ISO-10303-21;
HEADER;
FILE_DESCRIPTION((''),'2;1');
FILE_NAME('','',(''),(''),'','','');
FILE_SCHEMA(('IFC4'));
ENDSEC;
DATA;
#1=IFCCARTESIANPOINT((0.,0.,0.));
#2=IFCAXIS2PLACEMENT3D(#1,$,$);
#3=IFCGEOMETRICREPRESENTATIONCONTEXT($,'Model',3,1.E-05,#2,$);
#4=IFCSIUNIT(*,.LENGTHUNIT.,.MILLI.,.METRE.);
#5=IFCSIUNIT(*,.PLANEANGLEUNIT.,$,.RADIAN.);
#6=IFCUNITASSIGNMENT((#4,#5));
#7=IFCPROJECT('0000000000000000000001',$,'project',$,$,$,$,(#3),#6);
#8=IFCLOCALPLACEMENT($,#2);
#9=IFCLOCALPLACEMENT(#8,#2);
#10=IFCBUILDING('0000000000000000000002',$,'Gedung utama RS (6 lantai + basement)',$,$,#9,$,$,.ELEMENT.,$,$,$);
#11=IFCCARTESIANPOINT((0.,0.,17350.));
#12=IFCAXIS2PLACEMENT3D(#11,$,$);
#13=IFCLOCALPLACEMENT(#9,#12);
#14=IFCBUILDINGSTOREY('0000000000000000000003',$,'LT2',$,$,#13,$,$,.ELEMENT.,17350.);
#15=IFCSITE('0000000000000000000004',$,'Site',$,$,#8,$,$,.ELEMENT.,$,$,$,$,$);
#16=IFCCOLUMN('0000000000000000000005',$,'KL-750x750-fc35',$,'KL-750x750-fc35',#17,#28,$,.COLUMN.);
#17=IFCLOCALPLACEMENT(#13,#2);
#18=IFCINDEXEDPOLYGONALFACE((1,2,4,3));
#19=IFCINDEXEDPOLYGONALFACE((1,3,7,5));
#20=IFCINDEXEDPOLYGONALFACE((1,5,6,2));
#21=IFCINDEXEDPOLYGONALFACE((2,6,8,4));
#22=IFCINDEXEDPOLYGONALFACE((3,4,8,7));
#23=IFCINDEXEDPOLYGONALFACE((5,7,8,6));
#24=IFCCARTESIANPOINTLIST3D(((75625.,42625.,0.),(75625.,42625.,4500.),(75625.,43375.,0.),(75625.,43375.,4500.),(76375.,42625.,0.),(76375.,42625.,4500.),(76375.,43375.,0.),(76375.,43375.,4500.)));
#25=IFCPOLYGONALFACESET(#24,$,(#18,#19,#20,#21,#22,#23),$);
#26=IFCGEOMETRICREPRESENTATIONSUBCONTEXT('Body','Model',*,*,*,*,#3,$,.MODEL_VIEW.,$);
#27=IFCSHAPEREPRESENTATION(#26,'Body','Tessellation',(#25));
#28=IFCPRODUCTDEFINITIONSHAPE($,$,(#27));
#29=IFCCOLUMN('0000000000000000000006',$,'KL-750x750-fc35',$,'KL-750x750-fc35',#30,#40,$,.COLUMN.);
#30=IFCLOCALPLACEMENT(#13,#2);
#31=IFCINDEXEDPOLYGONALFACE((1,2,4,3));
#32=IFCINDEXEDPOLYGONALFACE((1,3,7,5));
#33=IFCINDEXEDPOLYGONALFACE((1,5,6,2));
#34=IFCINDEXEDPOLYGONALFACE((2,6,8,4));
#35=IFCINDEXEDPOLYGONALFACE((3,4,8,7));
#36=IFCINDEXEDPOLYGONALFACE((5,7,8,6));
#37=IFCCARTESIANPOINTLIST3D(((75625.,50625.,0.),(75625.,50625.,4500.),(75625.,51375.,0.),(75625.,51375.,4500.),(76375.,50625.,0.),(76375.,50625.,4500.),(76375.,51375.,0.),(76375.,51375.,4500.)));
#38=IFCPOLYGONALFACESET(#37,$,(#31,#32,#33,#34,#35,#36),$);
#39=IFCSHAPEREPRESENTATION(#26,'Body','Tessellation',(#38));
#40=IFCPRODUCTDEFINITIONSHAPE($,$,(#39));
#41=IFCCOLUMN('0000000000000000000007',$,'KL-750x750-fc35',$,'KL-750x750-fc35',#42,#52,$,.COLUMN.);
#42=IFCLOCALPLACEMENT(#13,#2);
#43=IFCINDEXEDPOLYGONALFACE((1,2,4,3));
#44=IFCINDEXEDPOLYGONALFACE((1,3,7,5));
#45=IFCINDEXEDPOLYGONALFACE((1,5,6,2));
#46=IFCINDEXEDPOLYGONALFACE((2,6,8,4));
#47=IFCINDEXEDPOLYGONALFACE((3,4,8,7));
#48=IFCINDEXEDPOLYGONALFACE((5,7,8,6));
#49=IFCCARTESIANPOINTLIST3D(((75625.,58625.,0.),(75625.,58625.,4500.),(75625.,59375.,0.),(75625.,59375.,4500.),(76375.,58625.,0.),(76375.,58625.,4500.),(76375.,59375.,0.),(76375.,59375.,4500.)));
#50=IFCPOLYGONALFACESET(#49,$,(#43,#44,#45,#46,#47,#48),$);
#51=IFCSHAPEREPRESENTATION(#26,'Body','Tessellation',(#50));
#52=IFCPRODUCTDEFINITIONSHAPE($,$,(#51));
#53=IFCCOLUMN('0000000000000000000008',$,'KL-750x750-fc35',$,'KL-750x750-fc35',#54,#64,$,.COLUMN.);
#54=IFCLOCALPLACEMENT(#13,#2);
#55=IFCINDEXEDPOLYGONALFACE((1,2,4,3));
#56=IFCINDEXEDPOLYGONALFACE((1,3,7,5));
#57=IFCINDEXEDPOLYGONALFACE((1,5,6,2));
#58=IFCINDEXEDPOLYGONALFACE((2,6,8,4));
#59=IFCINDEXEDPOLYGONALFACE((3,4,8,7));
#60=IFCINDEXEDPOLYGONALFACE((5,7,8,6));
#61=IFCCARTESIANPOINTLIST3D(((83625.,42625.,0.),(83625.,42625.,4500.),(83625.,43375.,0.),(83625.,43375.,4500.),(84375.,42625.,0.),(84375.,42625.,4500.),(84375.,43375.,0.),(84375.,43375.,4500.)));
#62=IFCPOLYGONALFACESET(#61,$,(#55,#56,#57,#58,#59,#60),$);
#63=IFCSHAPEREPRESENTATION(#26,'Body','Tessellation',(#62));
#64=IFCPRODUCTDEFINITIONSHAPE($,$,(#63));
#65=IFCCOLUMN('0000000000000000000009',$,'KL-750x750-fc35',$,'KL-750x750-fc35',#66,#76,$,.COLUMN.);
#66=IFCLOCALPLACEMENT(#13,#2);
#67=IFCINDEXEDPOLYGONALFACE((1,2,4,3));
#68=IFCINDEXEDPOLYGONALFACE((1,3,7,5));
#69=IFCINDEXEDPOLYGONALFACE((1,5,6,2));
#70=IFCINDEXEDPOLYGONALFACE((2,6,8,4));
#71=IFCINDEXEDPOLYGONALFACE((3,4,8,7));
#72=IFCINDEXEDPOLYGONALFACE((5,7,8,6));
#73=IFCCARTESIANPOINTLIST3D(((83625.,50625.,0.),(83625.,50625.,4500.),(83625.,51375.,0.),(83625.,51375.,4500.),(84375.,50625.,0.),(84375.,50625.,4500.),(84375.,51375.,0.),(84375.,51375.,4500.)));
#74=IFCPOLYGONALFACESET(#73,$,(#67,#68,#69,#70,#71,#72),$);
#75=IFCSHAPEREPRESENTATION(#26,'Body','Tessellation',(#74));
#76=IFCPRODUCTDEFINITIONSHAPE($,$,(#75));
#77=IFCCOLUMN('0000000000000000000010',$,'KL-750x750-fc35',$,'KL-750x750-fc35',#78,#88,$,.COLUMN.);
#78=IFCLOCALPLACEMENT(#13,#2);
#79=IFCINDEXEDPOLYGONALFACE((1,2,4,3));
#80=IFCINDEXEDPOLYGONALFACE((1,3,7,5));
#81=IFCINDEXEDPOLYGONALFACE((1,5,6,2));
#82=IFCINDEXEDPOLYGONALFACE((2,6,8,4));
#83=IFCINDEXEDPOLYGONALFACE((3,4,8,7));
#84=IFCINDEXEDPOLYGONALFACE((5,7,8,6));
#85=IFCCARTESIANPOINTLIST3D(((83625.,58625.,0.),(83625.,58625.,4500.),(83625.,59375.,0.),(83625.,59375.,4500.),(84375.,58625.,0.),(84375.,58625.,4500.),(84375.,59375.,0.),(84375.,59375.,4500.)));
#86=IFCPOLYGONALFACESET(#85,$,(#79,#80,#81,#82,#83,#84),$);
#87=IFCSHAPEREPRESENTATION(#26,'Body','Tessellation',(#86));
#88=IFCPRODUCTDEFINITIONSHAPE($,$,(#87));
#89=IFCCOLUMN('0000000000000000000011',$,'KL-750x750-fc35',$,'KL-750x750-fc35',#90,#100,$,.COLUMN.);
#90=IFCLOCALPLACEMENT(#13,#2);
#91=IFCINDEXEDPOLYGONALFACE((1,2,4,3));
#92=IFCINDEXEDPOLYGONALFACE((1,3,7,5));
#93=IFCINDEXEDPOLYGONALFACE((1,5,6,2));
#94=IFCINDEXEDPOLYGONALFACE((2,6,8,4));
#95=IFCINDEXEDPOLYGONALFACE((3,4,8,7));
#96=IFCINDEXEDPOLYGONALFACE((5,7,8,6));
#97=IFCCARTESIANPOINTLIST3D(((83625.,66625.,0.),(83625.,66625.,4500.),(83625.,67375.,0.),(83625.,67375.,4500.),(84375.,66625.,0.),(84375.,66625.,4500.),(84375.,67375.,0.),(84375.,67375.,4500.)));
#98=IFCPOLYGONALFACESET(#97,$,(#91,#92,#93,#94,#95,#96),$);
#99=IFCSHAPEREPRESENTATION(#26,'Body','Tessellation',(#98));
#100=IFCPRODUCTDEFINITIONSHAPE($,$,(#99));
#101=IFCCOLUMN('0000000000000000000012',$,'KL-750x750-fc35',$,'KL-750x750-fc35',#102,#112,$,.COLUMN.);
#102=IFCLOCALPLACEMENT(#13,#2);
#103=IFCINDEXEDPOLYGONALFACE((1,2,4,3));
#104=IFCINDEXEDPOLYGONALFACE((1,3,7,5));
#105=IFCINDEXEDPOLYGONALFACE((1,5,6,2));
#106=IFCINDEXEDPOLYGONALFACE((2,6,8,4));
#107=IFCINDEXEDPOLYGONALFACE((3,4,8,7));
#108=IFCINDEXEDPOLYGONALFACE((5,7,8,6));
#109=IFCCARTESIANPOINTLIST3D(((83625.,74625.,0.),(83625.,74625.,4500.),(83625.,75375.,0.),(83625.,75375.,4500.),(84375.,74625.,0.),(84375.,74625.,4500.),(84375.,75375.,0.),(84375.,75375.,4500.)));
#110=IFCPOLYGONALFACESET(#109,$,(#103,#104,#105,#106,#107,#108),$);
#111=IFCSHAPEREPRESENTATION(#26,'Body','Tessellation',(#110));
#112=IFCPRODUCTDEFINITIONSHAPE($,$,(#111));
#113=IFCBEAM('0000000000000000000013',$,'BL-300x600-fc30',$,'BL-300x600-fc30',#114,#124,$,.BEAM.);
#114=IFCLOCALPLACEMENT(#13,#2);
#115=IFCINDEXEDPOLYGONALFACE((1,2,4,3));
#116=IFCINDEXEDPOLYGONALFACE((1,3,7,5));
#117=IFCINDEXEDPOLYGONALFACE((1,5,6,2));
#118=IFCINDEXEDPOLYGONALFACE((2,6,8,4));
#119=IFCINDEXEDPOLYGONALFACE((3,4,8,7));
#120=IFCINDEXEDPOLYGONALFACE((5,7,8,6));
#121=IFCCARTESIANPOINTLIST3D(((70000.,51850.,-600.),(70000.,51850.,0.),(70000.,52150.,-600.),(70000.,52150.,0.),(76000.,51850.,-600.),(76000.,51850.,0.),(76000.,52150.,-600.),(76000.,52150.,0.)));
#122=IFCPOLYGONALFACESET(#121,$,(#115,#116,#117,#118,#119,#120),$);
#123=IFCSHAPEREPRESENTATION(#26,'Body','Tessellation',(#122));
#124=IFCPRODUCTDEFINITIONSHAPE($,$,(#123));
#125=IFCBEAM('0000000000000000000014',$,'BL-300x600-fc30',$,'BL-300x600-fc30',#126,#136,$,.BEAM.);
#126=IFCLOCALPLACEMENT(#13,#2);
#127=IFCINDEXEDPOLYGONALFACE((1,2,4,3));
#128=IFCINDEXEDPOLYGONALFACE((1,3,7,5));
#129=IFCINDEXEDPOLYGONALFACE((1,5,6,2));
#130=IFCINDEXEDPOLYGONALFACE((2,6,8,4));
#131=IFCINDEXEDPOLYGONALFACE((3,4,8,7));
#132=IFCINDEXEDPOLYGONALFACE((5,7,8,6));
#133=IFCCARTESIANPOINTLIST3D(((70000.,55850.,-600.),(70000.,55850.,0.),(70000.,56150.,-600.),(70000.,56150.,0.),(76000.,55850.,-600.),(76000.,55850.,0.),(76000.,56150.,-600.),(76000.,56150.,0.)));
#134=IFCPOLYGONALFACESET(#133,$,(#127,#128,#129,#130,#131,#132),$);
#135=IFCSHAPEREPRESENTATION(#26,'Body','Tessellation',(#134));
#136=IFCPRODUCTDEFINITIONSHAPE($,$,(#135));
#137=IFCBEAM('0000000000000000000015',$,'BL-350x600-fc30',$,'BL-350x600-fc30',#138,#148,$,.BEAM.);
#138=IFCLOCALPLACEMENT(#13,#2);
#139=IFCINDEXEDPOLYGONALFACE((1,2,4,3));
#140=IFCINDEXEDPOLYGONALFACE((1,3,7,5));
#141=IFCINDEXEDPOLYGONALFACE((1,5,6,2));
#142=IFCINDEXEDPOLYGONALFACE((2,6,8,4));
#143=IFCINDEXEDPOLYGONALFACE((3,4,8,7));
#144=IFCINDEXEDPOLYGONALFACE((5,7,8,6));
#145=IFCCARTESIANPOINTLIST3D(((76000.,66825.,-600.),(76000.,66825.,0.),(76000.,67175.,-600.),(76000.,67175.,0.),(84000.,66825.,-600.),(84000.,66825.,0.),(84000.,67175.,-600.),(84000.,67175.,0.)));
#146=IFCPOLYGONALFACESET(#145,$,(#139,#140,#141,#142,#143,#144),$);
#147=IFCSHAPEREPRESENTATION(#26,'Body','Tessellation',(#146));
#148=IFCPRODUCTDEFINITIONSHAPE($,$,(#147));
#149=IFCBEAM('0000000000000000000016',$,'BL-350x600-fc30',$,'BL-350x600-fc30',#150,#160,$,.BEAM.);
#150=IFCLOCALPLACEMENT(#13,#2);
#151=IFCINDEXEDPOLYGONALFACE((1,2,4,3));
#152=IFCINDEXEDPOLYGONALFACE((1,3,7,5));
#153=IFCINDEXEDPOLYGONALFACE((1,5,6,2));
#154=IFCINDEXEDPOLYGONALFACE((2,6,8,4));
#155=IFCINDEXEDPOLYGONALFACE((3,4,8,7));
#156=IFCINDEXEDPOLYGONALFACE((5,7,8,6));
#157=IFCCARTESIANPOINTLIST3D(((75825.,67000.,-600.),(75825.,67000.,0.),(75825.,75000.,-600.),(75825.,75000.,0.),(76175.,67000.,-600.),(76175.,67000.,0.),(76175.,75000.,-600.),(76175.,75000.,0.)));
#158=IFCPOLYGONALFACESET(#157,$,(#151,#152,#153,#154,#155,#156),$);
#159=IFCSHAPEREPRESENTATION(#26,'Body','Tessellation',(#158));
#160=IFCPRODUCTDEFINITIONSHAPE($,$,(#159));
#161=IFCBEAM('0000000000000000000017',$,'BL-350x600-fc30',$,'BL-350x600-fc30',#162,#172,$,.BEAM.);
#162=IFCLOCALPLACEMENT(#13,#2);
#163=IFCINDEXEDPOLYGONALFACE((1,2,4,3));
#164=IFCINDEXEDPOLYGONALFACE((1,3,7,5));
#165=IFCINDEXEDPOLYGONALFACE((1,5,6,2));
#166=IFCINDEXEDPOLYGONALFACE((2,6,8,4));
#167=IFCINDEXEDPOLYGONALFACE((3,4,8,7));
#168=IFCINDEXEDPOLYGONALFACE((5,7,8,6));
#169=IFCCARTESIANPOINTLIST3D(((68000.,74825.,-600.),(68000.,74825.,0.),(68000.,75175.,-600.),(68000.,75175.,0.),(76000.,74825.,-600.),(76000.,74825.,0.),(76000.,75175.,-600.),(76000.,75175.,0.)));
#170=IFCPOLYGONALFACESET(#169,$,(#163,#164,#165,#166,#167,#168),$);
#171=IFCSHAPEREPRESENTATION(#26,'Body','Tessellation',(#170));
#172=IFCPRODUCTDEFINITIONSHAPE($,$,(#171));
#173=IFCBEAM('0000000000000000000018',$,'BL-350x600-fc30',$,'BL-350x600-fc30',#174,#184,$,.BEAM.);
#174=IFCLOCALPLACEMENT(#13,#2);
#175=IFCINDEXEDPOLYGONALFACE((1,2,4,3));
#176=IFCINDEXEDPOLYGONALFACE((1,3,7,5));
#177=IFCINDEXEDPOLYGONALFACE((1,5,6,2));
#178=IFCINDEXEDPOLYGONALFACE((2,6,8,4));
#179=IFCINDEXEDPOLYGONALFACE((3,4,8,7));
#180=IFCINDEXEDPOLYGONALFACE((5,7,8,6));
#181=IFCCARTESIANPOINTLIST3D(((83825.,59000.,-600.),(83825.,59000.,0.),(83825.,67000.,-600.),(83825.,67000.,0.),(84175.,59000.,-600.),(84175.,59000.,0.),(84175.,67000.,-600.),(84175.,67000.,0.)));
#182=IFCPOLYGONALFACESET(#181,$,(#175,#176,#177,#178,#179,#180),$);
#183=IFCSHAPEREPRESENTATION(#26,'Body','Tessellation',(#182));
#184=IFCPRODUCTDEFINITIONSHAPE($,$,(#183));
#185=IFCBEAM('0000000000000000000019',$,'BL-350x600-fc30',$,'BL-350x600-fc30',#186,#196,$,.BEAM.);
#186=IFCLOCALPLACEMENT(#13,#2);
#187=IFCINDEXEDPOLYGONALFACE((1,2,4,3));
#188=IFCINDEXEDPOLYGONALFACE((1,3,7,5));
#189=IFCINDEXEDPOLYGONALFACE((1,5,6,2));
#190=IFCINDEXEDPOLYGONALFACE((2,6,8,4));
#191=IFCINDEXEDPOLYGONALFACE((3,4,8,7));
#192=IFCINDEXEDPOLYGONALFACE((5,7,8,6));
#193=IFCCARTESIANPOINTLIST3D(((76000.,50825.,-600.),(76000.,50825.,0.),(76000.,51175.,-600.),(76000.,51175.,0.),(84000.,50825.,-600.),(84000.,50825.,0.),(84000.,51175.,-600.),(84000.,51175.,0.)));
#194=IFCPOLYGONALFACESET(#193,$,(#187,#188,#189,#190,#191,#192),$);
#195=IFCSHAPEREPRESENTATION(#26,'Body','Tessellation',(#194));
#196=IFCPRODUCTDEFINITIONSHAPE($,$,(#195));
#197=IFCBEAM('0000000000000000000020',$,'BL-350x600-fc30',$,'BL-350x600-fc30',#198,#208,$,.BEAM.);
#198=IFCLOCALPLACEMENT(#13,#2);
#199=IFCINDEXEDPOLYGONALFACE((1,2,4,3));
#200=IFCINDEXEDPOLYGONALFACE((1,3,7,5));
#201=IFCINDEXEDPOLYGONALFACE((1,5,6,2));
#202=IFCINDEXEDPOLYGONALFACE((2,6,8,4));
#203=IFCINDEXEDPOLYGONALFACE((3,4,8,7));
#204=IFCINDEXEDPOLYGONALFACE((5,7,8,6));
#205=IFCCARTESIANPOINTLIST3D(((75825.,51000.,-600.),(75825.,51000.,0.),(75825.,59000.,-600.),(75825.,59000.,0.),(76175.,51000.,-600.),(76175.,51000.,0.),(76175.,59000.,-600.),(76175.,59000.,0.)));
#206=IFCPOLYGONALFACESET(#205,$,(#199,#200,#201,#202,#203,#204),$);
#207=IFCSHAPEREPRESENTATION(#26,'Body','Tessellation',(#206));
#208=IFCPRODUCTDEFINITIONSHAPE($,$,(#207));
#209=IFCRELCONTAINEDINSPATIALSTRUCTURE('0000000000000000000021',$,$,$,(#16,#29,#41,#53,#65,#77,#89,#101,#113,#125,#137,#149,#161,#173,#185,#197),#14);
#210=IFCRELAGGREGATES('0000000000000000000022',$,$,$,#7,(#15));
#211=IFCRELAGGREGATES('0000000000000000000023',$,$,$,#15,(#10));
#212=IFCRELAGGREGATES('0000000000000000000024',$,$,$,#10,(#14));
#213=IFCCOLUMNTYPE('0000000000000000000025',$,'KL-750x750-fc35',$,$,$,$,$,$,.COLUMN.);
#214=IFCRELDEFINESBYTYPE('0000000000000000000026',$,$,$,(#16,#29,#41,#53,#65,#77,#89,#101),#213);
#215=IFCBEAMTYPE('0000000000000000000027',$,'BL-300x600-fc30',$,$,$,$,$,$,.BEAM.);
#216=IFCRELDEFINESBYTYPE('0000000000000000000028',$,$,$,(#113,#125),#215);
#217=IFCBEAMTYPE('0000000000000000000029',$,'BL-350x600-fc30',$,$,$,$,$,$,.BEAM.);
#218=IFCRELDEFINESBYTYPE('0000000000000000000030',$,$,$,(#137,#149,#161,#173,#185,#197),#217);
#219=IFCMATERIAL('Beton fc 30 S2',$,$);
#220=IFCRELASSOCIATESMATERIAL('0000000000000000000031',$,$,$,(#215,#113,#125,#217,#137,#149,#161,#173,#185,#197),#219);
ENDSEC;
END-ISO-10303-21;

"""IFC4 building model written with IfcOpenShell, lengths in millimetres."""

from ifc_helpers import new_model, si_unit, frame, origin, origin_2d, place, context, subcontext, project, spatial, rectangle, extrude, material, material_profile, profile_set, profile_usage, type_object, element, save


model = new_model("IFC4")

# Units and contexts
model_context = context("Model", 3, precision=1e-05, world=origin())
body_context = subcontext(model_context, "Body", "Model", "MODEL_VIEW")
ifc_project = project(units=[si_unit("LENGTHUNIT", "METRE", prefix="MILLI"), si_unit("PLANEANGLEUNIT", "RADIAN")], contexts=[model_context])

# Site, building, storey
site_placement = place(None, origin())
site = spatial("IfcSite", under=ifc_project, at=site_placement, Name="Site", CompositionType="ELEMENT")
building_placement = place(site_placement, origin())
building = spatial("IfcBuilding", under=site, at=building_placement, Name="Gedung utama RS (6 lantai + basement)", CompositionType="ELEMENT")
storey_placement = place(building_placement, frame((0.0, 0.0, 17350.0)))
storey = spatial("IfcBuildingStorey", under=building, at=storey_placement, Name="LT2", CompositionType="ELEMENT", Elevation=17350.0)

# Columns
ifc_material_profile_1 = material_profile(None, rectangle(XDim=750.0, YDim=750.0, at=origin_2d()), Name="KL-750x750-fc35")
ifc_profile_set_1 = profile_set([ifc_material_profile_1], Name="KL-750x750-fc35")
ifc_profile_usage_1 = profile_usage(ifc_profile_set_1, cardinal=5)
column_type = type_object("IfcColumnType", Name="KL-750x750-fc35", PredefinedType="COLUMN", material=ifc_profile_set_1)
for number, where, z_axis, x_axis, name in (
    (1, (76000.0, 43000.0, 0.0), (0.0, 0.0, 1.0), (1.0, 0.0, 0.0), "KL-750x750-fc35"),
    (2, (76000.0, 51000.0, 0.0), (0.0, 0.0, 1.0), (1.0, 0.0, 0.0), "KL-750x750-fc35"),
    (3, (76000.0, 59000.0, 0.0), (0.0, 0.0, 1.0), (1.0, 0.0, 0.0), "KL-750x750-fc35"),
    (4, (84000.0, 43000.0, 0.0), (0.0, 0.0, 1.0), (1.0, 0.0, 0.0), "KL-750x750-fc35"),
    (5, (84000.0, 51000.0, 0.0), (0.0, 0.0, 1.0), (1.0, 0.0, 0.0), "KL-750x750-fc35"),
    (6, (84000.0, 59000.0, 0.0), (0.0, 0.0, 1.0), (1.0, 0.0, 0.0), "KL-750x750-fc35"),
    (7, (84000.0, 67000.0, 0.0), (0.0, 0.0, 1.0), (1.0, 0.0, 0.0), "KL-750x750-fc35"),
    (8, (84000.0, 75000.0, 0.0), (0.0, 0.0, 1.0), (1.0, 0.0, 0.0), "KL-750x750-fc35"),
):
    element("IfcColumn", number, at=place(storey_placement, frame(where, z_axis=z_axis, x_axis=x_axis)), inside=storey, type_object=column_type, material=ifc_profile_usage_1, Name=name, ObjectType="KL-750x750-fc35", PredefinedType="COLUMN", context=body_context, shape_type="SweptSolid", body=[
        extrude(rectangle(XDim=750.0, YDim=750.0, at=origin_2d()), origin(), (0.0, 0.0, 1.0), 4500.0),
    ])

# Beams
ifc_material_1 = material(Name="Beton fc 30 S2")
ifc_material_profile_2 = material_profile(ifc_material_1, rectangle(XDim=300.0, YDim=600.0, at=origin_2d()), Name="BL-300x600-fc30")
ifc_profile_set_2 = profile_set([ifc_material_profile_2], Name="BL-300x600-fc30")
ifc_profile_usage_2 = profile_usage(ifc_profile_set_2, cardinal=8)
beam_type_1 = type_object("IfcBeamType", Name="BL-300x600-fc30", PredefinedType="BEAM", material=ifc_profile_set_2)
for number, where, name in (
    (9, (70000.0, 52000.0, -300.0), "BL-300x600-fc30"),
    (10, (70000.0, 56000.0, -300.0), "BL-300x600-fc30"),
):
    element("IfcBeam", number, at=place(storey_placement, frame(where)), inside=storey, type_object=beam_type_1, material=ifc_profile_usage_2, Name=name, ObjectType="BL-300x600-fc30", PredefinedType="BEAM", context=body_context, shape_type="SweptSolid", body=[
        extrude(rectangle(XDim=300.0, YDim=600.0, at=origin_2d()), frame((0.0, 0.0, 0.0), z_axis=(1.0, 0.0, 0.0), x_axis=(0.0, 1.0, 0.0)), (0.0, 0.0, 1.0), 6000.0),
    ])
ifc_material_profile_3 = material_profile(ifc_material_1, rectangle(XDim=350.0, YDim=600.0, at=origin_2d()), Name="BL-350x600-fc30")
ifc_profile_set_3 = profile_set([ifc_material_profile_3], Name="BL-350x600-fc30")
ifc_profile_usage_3 = profile_usage(ifc_profile_set_3, cardinal=8)
beam_type_2 = type_object("IfcBeamType", Name="BL-350x600-fc30", PredefinedType="BEAM", material=ifc_profile_set_3)
beam_1_placement = place(storey_placement, frame((76000.0, 67000.0, -300.0)))
element("IfcBeam", 11, at=beam_1_placement, inside=storey, type_object=beam_type_2, material=ifc_profile_usage_3, Name="BL-350x600-fc30", ObjectType="BL-350x600-fc30", PredefinedType="BEAM", context=body_context, shape_type="SweptSolid", body=[
    extrude(rectangle(XDim=350.0, YDim=600.0, at=origin_2d()), frame((0.0, 0.0, 0.0), z_axis=(1.0, 0.0, 0.0), x_axis=(0.0, 1.0, 0.0)), (0.0, 0.0, 1.0), 8000.0),
])
beam_2_placement = place(storey_placement, frame((76000.0, 67000.0, -300.0)))
element("IfcBeam", 12, at=beam_2_placement, inside=storey, type_object=beam_type_2, material=ifc_profile_usage_3, Name="BL-350x600-fc30", ObjectType="BL-350x600-fc30", PredefinedType="BEAM", context=body_context, shape_type="SweptSolid", body=[
    extrude(rectangle(XDim=350.0, YDim=600.0, at=origin_2d()), frame((0.0, 0.0, 0.0), z_axis=(0.0, 1.0, 0.0), x_axis=(-1.0, 0.0, 0.0)), (0.0, 0.0, 1.0), 8000.0),
])
beam_3_placement = place(storey_placement, frame((68000.0, 75000.0, -300.0)))
element("IfcBeam", 13, at=beam_3_placement, inside=storey, type_object=beam_type_2, material=ifc_profile_usage_3, Name="BL-350x600-fc30", ObjectType="BL-350x600-fc30", PredefinedType="BEAM", context=body_context, shape_type="SweptSolid", body=[
    extrude(rectangle(XDim=350.0, YDim=600.0, at=origin_2d()), frame((0.0, 0.0, 0.0), z_axis=(1.0, 0.0, 0.0), x_axis=(0.0, 1.0, 0.0)), (0.0, 0.0, 1.0), 8000.0),
])
beam_4_placement = place(storey_placement, frame((84000.0, 59000.0, -300.0)))
element("IfcBeam", 14, at=beam_4_placement, inside=storey, type_object=beam_type_2, material=ifc_profile_usage_3, Name="BL-350x600-fc30", ObjectType="BL-350x600-fc30", PredefinedType="BEAM", context=body_context, shape_type="SweptSolid", body=[
    extrude(rectangle(XDim=350.0, YDim=600.0, at=origin_2d()), frame((0.0, 0.0, 0.0), z_axis=(0.0, 1.0, 0.0), x_axis=(-1.0, 0.0, 0.0)), (0.0, 0.0, 1.0), 8000.0),
])
beam_5_placement = place(storey_placement, frame((76000.0, 51000.0, -300.0)))
element("IfcBeam", 15, at=beam_5_placement, inside=storey, type_object=beam_type_2, material=ifc_profile_usage_3, Name="BL-350x600-fc30", ObjectType="BL-350x600-fc30", PredefinedType="BEAM", context=body_context, shape_type="SweptSolid", body=[
    extrude(rectangle(XDim=350.0, YDim=600.0, at=origin_2d()), frame((0.0, 0.0, 0.0), z_axis=(1.0, 0.0, 0.0), x_axis=(0.0, 1.0, 0.0)), (0.0, 0.0, 1.0), 8000.0),
])
for number, where, name in (
    (16, (76000.0, 51000.0, -300.0), "BL-350x600-fc30"),
):
    element("IfcBeam", number, at=place(storey_placement, frame(where)), inside=storey, type_object=beam_type_2, material=ifc_profile_usage_3, Name=name, ObjectType="BL-350x600-fc30", PredefinedType="BEAM", context=body_context, shape_type="SweptSolid", body=[
        extrude(rectangle(XDim=350.0, YDim=600.0, at=origin_2d()), frame((0.0, 0.0, 0.0), z_axis=(0.0, 1.0, 0.0), x_axis=(-1.0, 0.0, 0.0)), (0.0, 0.0, 1.0), 8000.0),
    ])

save(model, "model.ifc")
